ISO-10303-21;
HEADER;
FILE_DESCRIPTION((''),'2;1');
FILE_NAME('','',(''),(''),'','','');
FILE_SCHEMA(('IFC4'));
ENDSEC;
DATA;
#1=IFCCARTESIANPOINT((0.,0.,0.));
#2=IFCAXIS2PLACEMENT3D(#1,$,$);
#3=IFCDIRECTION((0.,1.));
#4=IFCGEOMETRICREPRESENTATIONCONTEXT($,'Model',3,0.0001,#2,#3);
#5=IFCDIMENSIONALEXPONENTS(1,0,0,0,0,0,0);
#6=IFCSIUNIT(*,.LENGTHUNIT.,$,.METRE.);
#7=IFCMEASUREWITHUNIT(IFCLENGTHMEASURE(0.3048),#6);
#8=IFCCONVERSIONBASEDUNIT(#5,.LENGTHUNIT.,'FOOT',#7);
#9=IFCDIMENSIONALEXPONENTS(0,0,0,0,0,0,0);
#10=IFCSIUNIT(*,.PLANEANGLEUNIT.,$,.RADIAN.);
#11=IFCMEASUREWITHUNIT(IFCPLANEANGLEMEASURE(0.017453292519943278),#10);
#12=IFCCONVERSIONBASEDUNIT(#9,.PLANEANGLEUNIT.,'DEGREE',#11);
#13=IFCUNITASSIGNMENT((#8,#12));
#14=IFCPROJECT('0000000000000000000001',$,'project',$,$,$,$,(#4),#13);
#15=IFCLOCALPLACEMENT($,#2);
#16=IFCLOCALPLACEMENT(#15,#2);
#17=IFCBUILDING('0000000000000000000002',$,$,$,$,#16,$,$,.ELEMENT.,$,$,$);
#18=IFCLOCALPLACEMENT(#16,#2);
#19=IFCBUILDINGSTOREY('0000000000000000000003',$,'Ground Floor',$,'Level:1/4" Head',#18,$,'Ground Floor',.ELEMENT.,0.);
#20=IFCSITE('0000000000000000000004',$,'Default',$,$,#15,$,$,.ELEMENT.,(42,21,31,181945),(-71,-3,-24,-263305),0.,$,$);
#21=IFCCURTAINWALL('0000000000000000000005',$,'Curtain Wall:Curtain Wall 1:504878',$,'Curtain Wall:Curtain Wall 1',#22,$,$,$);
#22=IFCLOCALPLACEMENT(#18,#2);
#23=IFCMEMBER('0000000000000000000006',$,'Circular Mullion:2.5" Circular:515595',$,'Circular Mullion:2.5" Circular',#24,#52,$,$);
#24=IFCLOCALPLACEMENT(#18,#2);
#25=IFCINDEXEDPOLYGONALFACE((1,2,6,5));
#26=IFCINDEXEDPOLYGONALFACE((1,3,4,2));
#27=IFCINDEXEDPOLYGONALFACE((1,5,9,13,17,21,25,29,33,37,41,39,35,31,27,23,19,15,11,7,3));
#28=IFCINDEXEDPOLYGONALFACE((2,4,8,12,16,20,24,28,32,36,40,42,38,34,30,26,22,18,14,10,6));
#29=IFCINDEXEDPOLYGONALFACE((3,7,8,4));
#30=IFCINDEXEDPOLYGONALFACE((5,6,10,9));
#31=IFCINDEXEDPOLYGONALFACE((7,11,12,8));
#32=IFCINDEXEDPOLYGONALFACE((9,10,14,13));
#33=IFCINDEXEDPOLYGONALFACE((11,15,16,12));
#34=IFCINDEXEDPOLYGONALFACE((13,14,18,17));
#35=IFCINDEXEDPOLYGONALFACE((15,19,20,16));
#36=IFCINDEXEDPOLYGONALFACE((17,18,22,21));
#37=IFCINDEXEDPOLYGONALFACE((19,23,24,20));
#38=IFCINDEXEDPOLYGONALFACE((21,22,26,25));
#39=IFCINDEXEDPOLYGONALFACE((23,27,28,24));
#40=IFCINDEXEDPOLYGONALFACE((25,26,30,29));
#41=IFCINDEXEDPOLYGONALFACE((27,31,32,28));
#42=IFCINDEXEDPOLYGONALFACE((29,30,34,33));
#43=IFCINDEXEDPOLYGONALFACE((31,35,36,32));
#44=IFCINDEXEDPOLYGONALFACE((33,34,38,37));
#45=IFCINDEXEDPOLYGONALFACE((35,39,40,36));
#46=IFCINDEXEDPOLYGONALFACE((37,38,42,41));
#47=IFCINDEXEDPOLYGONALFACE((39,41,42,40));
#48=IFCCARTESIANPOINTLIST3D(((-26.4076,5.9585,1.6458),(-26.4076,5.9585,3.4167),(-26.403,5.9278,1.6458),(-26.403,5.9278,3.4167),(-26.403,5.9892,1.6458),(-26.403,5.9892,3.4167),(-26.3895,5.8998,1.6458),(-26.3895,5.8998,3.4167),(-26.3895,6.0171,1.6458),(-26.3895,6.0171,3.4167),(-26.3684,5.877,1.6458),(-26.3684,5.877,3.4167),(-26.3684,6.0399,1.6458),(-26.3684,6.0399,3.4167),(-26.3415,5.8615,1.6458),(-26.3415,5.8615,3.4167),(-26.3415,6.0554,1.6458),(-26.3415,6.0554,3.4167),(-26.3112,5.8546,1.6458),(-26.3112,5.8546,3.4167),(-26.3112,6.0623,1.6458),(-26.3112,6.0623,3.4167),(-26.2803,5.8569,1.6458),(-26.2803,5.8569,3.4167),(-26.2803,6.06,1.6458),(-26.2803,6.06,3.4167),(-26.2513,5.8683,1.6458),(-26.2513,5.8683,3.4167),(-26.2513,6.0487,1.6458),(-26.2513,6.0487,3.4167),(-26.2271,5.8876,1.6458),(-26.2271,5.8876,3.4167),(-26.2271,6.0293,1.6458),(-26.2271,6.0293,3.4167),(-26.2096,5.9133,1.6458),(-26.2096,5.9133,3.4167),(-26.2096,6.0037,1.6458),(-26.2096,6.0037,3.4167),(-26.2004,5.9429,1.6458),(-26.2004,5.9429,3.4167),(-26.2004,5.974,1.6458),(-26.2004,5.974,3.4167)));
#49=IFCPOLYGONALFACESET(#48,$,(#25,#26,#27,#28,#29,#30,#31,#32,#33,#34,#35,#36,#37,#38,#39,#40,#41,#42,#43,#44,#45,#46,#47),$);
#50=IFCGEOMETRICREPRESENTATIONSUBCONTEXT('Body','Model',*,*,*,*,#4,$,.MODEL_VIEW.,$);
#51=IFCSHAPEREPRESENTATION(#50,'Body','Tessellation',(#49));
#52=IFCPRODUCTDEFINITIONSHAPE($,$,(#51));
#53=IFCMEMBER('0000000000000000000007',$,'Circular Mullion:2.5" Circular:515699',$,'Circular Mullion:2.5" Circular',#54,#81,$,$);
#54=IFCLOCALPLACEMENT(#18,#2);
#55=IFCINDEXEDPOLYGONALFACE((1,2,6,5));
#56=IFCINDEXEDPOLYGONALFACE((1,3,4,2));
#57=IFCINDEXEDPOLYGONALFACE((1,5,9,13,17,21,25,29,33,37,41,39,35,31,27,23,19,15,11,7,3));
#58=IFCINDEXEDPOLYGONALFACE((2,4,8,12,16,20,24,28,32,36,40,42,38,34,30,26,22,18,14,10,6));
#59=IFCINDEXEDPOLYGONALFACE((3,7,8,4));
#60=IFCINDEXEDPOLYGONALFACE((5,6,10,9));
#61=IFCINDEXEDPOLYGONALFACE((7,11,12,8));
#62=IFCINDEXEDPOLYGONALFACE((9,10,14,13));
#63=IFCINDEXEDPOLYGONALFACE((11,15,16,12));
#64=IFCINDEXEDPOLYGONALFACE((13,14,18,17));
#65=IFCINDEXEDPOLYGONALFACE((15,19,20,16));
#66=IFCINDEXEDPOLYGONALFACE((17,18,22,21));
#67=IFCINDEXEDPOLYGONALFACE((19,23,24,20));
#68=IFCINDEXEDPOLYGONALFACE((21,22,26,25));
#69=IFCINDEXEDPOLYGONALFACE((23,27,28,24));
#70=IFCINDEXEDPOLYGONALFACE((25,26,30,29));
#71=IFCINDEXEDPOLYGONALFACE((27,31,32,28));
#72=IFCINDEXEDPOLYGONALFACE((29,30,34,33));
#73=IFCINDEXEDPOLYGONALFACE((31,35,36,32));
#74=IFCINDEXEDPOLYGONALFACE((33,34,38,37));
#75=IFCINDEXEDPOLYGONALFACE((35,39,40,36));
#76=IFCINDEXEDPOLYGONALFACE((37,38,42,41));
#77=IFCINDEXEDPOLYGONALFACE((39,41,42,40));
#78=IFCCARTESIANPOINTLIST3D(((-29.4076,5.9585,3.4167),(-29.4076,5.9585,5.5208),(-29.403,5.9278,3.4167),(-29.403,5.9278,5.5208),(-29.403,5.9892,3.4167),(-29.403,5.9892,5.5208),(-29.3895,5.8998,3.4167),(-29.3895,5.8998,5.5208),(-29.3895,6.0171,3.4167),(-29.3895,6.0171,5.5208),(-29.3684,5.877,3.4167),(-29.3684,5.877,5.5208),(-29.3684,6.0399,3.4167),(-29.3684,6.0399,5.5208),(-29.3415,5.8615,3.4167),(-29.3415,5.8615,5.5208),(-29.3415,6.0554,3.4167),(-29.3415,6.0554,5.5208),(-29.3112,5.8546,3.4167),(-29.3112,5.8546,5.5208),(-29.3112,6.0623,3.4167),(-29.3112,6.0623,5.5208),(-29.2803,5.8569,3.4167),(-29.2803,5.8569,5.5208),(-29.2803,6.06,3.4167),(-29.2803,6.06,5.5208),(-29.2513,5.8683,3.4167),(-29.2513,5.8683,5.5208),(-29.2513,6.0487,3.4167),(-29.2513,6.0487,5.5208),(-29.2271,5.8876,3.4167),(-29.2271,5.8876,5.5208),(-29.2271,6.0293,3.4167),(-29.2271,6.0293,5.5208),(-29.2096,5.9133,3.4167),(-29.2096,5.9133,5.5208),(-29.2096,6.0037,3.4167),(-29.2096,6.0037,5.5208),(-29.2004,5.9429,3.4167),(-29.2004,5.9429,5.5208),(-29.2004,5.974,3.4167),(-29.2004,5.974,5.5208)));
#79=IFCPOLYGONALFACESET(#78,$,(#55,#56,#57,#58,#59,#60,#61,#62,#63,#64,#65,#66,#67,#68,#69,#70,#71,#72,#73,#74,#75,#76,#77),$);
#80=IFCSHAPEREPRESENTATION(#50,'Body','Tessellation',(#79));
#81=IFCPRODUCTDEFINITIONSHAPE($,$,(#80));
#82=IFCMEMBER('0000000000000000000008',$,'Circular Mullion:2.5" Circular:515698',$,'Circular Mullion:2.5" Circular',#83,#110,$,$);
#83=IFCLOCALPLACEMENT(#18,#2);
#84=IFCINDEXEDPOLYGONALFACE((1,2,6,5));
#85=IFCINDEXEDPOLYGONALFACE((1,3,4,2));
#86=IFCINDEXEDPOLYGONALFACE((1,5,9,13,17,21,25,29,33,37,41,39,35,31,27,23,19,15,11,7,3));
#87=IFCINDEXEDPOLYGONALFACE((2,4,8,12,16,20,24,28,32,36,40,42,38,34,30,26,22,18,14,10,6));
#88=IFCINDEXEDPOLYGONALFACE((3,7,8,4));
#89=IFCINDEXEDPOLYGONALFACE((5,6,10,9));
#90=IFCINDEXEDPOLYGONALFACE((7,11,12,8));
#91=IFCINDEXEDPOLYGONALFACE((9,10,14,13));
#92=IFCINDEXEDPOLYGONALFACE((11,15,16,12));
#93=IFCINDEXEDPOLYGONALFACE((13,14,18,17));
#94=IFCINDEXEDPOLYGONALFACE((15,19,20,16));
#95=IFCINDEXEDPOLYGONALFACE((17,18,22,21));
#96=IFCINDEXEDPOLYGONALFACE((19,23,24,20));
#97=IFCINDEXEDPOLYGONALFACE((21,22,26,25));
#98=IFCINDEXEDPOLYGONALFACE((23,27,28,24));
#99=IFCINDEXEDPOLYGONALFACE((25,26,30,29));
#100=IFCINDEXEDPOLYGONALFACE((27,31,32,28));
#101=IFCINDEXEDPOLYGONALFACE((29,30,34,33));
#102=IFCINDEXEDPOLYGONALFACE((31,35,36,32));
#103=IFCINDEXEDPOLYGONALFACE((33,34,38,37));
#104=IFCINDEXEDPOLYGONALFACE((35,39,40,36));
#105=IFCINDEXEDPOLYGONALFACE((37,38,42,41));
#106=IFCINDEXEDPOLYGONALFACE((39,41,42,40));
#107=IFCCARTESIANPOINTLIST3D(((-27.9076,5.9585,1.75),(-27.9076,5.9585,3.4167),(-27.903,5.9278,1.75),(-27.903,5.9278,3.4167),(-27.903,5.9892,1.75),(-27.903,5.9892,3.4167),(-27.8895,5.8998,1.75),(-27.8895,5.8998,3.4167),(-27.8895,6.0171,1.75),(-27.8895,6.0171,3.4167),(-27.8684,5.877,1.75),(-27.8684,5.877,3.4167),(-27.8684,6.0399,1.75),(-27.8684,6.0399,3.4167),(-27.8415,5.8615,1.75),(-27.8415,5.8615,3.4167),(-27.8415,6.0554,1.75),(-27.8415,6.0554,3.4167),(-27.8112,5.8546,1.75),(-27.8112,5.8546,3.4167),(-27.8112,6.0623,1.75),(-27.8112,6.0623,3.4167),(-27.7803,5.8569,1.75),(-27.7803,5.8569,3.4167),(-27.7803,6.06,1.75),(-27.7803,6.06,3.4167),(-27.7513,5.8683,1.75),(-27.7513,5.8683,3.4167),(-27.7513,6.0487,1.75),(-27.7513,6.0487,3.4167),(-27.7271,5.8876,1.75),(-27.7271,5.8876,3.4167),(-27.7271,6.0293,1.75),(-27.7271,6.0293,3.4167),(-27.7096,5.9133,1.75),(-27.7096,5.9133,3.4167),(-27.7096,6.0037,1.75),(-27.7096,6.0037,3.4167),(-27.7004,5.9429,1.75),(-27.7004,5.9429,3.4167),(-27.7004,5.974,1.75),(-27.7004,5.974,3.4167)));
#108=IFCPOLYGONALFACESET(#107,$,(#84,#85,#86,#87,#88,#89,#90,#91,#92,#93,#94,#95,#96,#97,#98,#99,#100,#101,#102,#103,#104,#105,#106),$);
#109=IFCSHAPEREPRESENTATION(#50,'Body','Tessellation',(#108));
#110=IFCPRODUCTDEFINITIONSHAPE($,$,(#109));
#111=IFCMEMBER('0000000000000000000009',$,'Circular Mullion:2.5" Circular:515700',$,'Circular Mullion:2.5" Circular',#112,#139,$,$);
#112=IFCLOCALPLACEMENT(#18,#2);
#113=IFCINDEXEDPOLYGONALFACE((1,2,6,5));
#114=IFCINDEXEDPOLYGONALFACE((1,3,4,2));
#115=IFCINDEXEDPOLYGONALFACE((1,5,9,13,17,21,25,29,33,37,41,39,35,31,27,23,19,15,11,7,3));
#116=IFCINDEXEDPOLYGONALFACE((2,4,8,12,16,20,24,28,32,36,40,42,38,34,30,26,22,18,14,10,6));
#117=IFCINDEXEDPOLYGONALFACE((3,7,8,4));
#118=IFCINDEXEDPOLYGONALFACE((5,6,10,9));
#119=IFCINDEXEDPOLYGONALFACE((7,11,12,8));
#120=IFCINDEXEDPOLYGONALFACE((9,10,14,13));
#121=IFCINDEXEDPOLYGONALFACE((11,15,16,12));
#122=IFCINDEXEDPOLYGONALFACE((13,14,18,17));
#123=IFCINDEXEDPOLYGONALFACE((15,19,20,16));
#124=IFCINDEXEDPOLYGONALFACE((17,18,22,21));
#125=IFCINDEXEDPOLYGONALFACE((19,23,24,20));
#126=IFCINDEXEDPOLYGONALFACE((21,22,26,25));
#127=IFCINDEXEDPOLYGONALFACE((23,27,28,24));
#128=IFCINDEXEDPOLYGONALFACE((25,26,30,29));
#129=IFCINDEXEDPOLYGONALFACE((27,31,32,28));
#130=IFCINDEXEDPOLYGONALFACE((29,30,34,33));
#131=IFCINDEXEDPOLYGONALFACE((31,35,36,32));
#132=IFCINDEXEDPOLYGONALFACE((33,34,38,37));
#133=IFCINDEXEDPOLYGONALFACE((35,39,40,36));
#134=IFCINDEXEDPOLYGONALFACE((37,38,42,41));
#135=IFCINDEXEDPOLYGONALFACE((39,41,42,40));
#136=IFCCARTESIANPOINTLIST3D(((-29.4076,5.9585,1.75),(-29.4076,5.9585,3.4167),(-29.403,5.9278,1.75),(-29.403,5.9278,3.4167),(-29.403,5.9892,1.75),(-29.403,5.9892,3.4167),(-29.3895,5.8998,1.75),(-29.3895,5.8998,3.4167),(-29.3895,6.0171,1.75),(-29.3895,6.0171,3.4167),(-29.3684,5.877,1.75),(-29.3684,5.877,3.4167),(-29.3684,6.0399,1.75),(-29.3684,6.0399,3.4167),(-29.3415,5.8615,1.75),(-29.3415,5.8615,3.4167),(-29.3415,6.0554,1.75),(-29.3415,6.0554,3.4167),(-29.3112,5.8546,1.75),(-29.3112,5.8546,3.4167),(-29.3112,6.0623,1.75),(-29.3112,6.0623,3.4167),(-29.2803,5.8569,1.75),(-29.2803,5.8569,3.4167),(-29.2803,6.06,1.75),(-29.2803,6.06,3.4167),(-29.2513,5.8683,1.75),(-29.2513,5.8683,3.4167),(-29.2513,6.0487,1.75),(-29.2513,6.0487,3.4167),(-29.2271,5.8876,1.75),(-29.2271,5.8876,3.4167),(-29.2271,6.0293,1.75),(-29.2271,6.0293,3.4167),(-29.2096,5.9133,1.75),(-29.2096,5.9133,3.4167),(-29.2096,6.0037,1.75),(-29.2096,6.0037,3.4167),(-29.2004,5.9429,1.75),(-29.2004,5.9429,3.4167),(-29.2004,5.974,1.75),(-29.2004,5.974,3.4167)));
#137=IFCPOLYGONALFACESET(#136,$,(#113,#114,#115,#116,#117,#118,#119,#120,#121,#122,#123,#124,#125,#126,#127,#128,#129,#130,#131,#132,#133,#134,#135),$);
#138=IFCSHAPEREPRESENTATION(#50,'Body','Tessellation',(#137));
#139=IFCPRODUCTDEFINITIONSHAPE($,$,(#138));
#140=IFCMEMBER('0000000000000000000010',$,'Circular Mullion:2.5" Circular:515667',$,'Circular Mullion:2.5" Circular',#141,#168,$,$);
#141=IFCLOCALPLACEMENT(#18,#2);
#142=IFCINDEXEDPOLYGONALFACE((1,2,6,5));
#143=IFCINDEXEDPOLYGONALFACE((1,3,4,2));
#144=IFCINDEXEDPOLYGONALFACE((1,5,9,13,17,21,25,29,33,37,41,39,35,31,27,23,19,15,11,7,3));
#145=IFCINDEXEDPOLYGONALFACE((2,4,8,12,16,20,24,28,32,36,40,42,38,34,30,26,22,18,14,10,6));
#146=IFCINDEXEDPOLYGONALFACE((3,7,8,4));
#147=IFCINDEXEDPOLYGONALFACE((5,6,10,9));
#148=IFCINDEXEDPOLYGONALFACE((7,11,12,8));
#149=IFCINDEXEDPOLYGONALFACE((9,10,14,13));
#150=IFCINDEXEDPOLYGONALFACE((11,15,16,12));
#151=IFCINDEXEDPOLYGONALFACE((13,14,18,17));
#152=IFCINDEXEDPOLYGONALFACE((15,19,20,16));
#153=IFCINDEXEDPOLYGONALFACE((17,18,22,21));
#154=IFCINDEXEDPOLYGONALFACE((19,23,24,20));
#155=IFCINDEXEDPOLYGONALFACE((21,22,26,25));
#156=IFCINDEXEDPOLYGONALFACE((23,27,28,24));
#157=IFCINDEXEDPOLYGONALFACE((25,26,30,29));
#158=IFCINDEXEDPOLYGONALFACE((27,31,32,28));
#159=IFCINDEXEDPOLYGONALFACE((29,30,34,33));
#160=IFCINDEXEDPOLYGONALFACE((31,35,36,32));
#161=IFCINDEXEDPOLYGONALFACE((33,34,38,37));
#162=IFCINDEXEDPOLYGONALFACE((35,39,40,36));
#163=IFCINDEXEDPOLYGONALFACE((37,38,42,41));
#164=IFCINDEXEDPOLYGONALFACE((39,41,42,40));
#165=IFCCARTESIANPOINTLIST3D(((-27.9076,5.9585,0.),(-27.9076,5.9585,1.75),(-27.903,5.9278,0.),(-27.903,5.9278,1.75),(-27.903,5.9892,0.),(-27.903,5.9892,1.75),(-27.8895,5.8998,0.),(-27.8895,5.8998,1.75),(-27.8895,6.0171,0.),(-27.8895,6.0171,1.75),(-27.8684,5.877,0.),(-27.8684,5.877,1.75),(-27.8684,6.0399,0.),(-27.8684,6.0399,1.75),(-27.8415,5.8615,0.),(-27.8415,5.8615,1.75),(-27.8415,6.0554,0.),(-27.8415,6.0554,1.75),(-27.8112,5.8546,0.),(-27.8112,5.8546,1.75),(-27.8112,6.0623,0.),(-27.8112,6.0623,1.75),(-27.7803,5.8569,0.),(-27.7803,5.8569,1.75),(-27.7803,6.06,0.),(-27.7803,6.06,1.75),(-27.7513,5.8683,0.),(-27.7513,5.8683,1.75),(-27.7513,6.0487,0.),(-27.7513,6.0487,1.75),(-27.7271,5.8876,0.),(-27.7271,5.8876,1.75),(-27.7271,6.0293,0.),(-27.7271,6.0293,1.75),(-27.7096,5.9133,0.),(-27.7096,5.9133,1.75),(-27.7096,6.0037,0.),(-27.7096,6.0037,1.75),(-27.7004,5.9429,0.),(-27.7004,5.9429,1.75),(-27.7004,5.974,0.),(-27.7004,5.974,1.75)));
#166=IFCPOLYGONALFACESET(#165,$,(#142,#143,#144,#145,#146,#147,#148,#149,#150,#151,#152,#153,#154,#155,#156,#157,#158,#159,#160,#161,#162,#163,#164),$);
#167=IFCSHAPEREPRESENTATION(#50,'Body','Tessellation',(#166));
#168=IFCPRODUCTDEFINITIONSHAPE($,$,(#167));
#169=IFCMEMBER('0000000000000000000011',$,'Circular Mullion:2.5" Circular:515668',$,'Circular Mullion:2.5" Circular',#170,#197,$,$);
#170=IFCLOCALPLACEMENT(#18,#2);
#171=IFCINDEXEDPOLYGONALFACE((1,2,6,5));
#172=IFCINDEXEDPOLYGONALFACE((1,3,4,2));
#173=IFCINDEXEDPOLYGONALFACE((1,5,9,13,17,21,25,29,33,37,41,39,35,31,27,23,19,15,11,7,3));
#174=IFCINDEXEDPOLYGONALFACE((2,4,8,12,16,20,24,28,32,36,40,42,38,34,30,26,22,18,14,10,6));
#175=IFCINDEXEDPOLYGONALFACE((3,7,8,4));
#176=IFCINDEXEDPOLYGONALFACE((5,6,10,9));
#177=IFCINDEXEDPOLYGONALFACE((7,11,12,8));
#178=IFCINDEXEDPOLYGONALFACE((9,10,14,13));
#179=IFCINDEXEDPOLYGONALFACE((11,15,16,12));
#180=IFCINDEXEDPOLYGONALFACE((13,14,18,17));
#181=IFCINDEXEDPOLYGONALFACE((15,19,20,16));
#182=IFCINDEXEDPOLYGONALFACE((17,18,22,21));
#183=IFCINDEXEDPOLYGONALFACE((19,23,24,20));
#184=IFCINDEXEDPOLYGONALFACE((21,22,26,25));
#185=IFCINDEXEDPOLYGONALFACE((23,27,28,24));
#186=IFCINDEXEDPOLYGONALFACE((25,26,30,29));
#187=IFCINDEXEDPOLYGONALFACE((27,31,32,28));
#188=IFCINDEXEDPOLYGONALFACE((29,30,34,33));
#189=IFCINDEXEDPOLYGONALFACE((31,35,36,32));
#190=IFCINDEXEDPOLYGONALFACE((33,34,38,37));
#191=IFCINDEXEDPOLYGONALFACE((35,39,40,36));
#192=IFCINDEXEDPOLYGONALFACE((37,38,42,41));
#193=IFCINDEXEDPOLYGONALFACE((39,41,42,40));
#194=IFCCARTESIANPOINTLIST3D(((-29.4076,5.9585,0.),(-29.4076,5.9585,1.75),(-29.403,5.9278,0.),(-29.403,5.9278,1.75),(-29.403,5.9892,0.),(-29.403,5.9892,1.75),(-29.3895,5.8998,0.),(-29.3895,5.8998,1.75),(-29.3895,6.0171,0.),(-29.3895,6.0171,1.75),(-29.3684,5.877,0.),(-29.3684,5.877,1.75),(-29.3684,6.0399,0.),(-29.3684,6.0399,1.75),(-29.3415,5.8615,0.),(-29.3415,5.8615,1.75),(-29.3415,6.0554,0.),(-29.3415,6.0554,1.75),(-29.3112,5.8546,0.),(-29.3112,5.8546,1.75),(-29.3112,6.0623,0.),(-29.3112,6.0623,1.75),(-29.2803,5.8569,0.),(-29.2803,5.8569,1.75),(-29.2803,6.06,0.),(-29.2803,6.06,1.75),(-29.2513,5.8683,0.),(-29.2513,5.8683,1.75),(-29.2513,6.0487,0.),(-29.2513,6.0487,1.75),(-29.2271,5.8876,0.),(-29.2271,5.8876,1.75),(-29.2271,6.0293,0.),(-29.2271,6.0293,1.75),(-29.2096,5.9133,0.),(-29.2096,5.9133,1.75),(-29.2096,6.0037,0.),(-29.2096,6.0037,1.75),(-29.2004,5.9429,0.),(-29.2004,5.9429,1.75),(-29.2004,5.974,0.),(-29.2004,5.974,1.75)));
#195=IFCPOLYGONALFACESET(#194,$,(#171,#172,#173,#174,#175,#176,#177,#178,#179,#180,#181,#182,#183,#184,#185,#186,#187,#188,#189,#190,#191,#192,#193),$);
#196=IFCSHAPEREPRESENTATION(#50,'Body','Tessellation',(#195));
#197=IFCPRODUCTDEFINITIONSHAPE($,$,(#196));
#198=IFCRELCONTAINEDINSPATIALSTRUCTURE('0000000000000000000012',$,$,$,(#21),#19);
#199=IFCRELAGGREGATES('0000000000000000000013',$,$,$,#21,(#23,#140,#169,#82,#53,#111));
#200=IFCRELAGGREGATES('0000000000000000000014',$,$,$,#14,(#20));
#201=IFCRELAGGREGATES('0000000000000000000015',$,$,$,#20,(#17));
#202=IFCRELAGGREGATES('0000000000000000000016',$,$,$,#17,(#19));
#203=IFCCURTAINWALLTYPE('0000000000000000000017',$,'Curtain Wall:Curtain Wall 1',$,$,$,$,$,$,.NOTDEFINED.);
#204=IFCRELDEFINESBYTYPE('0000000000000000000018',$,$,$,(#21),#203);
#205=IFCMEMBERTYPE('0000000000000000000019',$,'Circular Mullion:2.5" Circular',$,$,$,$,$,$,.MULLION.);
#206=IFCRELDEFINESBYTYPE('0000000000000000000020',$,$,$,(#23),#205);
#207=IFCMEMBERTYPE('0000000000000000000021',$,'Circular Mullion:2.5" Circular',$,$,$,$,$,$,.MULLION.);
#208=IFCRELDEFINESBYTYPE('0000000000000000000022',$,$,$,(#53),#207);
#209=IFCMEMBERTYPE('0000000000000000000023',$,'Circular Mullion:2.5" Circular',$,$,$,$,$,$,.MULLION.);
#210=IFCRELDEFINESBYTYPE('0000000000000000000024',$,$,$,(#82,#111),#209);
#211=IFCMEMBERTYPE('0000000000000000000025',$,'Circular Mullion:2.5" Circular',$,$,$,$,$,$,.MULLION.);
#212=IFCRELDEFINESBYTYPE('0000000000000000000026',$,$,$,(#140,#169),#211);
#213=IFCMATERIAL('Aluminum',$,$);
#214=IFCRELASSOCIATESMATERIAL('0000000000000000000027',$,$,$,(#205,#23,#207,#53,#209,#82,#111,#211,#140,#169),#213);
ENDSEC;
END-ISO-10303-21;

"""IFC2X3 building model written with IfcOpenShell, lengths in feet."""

from ifc_helpers import new_model, entity, si_unit, converted_unit, direction, frame, frame_2d, origin, place, context, subcontext, project, spatial, circle, extrude, source, transform, mapped, material, type_object, type_shapes, element, aggregate, save


model = new_model("IFC2X3")

# Units and contexts
model_context = context("Model", 3, precision=0.0001, world=origin(), true_north=direction((0.0, 1.0)))
body_context = subcontext(model_context, "Body", "Model", "MODEL_VIEW")
ifc_project = project(units=[converted_unit("LENGTHUNIT", "FOOT", entity("IfcLengthMeasure", 0.3048), si_unit("LENGTHUNIT", "METRE"), dimensions=[1, 0, 0, 0, 0, 0, 0]), converted_unit("PLANEANGLEUNIT", "DEGREE", entity("IfcPlaneAngleMeasure", 0.017453292519943278), si_unit("PLANEANGLEUNIT", "RADIAN"), dimensions=[0, 0, 0, 0, 0, 0, 0])], contexts=[model_context])

# Site, building, storey
site_placement = place(None, origin())
site = spatial("IfcSite", under=ifc_project, at=site_placement, Name="Default", CompositionType="ELEMENT", RefLatitude=(42, 21, 31, 181945), RefLongitude=(-71, -3, -24, -263305), RefElevation=0.0)
building_placement = place(site_placement, origin())
building = spatial("IfcBuilding", under=site, at=building_placement, CompositionType="ELEMENT")
storey_placement = place(building_placement, origin())
storey = spatial("IfcBuildingStorey", under=building, at=storey_placement, Name="Ground Floor", ObjectType="Level:1/4\" Head", LongName="Ground Floor", CompositionType="ELEMENT", Elevation=0.0)

# Curtain wall, members
curtain_wall_type = type_object("IfcCurtainWallType", Name="Curtain Wall:Curtain Wall 1", PredefinedType="NOTDEFINED")
curtain_wall_placement = place(storey_placement, origin())
curtain_wall = element("IfcCurtainWall", 1, at=curtain_wall_placement, inside=storey, type_object=curtain_wall_type, Name="Curtain Wall:Curtain Wall 1:504878", ObjectType="Curtain Wall:Curtain Wall 1")
ifc_material_1 = material(Name="Aluminum")
member_type_1 = type_object("IfcMemberType", Name="Circular Mullion:2.5\" Circular", PredefinedType="MULLION", material=ifc_material_1)
shared_shape_1 = source(origin(), body_context, "Body", "SweptSolid", [
    extrude(circle(Radius=0.1042, at=frame_2d((0.0, 0.0), x_axis=(1.0, 0.0))), frame((0.0, 0.0, -1.7708)), (0.0, 0.0, 1.0), 1.7708),
])
type_shapes(member_type_1, [shared_shape_1])
member_1_placement = place(curtain_wall_placement, frame((-26.3034, 5.9585, 1.6458), z_axis=(0.0, 0.0, -1.0), x_axis=(-1.0, 0.0, 0.0)))
member_1 = element("IfcMember", 2, at=member_1_placement, type_object=member_type_1, material=ifc_material_1, Name="Circular Mullion:2.5\" Circular:515595", ObjectType="Circular Mullion:2.5\" Circular", context=body_context, shape_type="MappedRepresentation", body=[
    mapped(shared_shape_1, transform((0.0, 0.0, 0.0), scale=1.0)),
])
member_type_2 = type_object("IfcMemberType", Name="Circular Mullion:2.5\" Circular", PredefinedType="MULLION", material=ifc_material_1)
shared_shape_2 = source(origin(), body_context, "Body", "SweptSolid", [
    extrude(circle(Radius=0.1042, at=frame_2d((0.0, 0.0), x_axis=(1.0, 0.0))), frame((0.0, 0.0, -2.1042)), (0.0, 0.0, 1.0), 2.1042),
])
type_shapes(member_type_2, [shared_shape_2])
member_2_placement = place(curtain_wall_placement, frame((-29.3034, 5.9585, 3.4167), z_axis=(0.0, 0.0, -1.0), x_axis=(-1.0, 0.0, 0.0)))
member_2 = element("IfcMember", 3, at=member_2_placement, type_object=member_type_2, material=ifc_material_1, Name="Circular Mullion:2.5\" Circular:515699", ObjectType="Circular Mullion:2.5\" Circular", context=body_context, shape_type="MappedRepresentation", body=[
    mapped(shared_shape_2, transform((0.0, 0.0, 0.0), scale=1.0)),
])
member_type_3 = type_object("IfcMemberType", Name="Circular Mullion:2.5\" Circular", PredefinedType="MULLION", material=ifc_material_1)
shared_shape_3 = source(origin(), body_context, "Body", "SweptSolid", [
    extrude(circle(Radius=0.1042, at=frame_2d((0.0, 0.0), x_axis=(1.0, 0.0))), frame((0.0, 0.0, -1.6667)), (0.0, 0.0, 1.0), 1.6667),
])
type_shapes(member_type_3, [shared_shape_3])
member_3_placement = place(curtain_wall_placement, frame((-27.8034, 5.9585, 1.75), z_axis=(0.0, 0.0, -1.0), x_axis=(-1.0, 0.0, 0.0)))
member_3 = element("IfcMember", 4, at=member_3_placement, type_object=member_type_3, material=ifc_material_1, Name="Circular Mullion:2.5\" Circular:515698", ObjectType="Circular Mullion:2.5\" Circular", context=body_context, shape_type="MappedRepresentation", body=[
    mapped(shared_shape_3, transform((0.0, 0.0, 0.0), scale=1.0)),
])
member_4_placement = place(curtain_wall_placement, frame((-29.3034, 5.9585, 1.75), z_axis=(0.0, 0.0, -1.0), x_axis=(-1.0, 0.0, 0.0)))
member_4 = element("IfcMember", 5, at=member_4_placement, type_object=member_type_3, material=ifc_material_1, Name="Circular Mullion:2.5\" Circular:515700", ObjectType="Circular Mullion:2.5\" Circular", context=body_context, shape_type="MappedRepresentation", body=[
    mapped(shared_shape_3, transform((0.0, 0.0, 0.0), scale=1.0)),
])
member_type_4 = type_object("IfcMemberType", Name="Circular Mullion:2.5\" Circular", PredefinedType="MULLION", material=ifc_material_1)
shared_shape_4 = source(origin(), body_context, "Body", "SweptSolid", [
    extrude(circle(Radius=0.1042, at=frame_2d((0.0, 0.0), x_axis=(1.0, 0.0))), frame((0.0, 0.0, -1.75)), (0.0, 0.0, 1.0), 1.75),
])
type_shapes(member_type_4, [shared_shape_4])
member_5_placement = place(curtain_wall_placement, frame((-27.8034, 5.9585, 0.0), z_axis=(0.0, 0.0, -1.0), x_axis=(-1.0, 0.0, 0.0)))
member_5 = element("IfcMember", 6, at=member_5_placement, type_object=member_type_4, material=ifc_material_1, Name="Circular Mullion:2.5\" Circular:515667", ObjectType="Circular Mullion:2.5\" Circular", context=body_context, shape_type="MappedRepresentation", body=[
    mapped(shared_shape_4, transform((0.0, 0.0, 0.0), scale=1.0)),
])
member_6_placement = place(curtain_wall_placement, frame((-29.3034, 5.9585, 0.0), z_axis=(0.0, 0.0, -1.0), x_axis=(-1.0, 0.0, 0.0)))
member_6 = element("IfcMember", 7, at=member_6_placement, type_object=member_type_4, material=ifc_material_1, Name="Circular Mullion:2.5\" Circular:515668", ObjectType="Circular Mullion:2.5\" Circular", context=body_context, shape_type="MappedRepresentation", body=[
    mapped(shared_shape_4, transform((0.0, 0.0, 0.0), scale=1.0)),
])
aggregate(curtain_wall, [member_1, member_5, member_6, member_3, member_2, member_4])

save(model, "model.ifc")
